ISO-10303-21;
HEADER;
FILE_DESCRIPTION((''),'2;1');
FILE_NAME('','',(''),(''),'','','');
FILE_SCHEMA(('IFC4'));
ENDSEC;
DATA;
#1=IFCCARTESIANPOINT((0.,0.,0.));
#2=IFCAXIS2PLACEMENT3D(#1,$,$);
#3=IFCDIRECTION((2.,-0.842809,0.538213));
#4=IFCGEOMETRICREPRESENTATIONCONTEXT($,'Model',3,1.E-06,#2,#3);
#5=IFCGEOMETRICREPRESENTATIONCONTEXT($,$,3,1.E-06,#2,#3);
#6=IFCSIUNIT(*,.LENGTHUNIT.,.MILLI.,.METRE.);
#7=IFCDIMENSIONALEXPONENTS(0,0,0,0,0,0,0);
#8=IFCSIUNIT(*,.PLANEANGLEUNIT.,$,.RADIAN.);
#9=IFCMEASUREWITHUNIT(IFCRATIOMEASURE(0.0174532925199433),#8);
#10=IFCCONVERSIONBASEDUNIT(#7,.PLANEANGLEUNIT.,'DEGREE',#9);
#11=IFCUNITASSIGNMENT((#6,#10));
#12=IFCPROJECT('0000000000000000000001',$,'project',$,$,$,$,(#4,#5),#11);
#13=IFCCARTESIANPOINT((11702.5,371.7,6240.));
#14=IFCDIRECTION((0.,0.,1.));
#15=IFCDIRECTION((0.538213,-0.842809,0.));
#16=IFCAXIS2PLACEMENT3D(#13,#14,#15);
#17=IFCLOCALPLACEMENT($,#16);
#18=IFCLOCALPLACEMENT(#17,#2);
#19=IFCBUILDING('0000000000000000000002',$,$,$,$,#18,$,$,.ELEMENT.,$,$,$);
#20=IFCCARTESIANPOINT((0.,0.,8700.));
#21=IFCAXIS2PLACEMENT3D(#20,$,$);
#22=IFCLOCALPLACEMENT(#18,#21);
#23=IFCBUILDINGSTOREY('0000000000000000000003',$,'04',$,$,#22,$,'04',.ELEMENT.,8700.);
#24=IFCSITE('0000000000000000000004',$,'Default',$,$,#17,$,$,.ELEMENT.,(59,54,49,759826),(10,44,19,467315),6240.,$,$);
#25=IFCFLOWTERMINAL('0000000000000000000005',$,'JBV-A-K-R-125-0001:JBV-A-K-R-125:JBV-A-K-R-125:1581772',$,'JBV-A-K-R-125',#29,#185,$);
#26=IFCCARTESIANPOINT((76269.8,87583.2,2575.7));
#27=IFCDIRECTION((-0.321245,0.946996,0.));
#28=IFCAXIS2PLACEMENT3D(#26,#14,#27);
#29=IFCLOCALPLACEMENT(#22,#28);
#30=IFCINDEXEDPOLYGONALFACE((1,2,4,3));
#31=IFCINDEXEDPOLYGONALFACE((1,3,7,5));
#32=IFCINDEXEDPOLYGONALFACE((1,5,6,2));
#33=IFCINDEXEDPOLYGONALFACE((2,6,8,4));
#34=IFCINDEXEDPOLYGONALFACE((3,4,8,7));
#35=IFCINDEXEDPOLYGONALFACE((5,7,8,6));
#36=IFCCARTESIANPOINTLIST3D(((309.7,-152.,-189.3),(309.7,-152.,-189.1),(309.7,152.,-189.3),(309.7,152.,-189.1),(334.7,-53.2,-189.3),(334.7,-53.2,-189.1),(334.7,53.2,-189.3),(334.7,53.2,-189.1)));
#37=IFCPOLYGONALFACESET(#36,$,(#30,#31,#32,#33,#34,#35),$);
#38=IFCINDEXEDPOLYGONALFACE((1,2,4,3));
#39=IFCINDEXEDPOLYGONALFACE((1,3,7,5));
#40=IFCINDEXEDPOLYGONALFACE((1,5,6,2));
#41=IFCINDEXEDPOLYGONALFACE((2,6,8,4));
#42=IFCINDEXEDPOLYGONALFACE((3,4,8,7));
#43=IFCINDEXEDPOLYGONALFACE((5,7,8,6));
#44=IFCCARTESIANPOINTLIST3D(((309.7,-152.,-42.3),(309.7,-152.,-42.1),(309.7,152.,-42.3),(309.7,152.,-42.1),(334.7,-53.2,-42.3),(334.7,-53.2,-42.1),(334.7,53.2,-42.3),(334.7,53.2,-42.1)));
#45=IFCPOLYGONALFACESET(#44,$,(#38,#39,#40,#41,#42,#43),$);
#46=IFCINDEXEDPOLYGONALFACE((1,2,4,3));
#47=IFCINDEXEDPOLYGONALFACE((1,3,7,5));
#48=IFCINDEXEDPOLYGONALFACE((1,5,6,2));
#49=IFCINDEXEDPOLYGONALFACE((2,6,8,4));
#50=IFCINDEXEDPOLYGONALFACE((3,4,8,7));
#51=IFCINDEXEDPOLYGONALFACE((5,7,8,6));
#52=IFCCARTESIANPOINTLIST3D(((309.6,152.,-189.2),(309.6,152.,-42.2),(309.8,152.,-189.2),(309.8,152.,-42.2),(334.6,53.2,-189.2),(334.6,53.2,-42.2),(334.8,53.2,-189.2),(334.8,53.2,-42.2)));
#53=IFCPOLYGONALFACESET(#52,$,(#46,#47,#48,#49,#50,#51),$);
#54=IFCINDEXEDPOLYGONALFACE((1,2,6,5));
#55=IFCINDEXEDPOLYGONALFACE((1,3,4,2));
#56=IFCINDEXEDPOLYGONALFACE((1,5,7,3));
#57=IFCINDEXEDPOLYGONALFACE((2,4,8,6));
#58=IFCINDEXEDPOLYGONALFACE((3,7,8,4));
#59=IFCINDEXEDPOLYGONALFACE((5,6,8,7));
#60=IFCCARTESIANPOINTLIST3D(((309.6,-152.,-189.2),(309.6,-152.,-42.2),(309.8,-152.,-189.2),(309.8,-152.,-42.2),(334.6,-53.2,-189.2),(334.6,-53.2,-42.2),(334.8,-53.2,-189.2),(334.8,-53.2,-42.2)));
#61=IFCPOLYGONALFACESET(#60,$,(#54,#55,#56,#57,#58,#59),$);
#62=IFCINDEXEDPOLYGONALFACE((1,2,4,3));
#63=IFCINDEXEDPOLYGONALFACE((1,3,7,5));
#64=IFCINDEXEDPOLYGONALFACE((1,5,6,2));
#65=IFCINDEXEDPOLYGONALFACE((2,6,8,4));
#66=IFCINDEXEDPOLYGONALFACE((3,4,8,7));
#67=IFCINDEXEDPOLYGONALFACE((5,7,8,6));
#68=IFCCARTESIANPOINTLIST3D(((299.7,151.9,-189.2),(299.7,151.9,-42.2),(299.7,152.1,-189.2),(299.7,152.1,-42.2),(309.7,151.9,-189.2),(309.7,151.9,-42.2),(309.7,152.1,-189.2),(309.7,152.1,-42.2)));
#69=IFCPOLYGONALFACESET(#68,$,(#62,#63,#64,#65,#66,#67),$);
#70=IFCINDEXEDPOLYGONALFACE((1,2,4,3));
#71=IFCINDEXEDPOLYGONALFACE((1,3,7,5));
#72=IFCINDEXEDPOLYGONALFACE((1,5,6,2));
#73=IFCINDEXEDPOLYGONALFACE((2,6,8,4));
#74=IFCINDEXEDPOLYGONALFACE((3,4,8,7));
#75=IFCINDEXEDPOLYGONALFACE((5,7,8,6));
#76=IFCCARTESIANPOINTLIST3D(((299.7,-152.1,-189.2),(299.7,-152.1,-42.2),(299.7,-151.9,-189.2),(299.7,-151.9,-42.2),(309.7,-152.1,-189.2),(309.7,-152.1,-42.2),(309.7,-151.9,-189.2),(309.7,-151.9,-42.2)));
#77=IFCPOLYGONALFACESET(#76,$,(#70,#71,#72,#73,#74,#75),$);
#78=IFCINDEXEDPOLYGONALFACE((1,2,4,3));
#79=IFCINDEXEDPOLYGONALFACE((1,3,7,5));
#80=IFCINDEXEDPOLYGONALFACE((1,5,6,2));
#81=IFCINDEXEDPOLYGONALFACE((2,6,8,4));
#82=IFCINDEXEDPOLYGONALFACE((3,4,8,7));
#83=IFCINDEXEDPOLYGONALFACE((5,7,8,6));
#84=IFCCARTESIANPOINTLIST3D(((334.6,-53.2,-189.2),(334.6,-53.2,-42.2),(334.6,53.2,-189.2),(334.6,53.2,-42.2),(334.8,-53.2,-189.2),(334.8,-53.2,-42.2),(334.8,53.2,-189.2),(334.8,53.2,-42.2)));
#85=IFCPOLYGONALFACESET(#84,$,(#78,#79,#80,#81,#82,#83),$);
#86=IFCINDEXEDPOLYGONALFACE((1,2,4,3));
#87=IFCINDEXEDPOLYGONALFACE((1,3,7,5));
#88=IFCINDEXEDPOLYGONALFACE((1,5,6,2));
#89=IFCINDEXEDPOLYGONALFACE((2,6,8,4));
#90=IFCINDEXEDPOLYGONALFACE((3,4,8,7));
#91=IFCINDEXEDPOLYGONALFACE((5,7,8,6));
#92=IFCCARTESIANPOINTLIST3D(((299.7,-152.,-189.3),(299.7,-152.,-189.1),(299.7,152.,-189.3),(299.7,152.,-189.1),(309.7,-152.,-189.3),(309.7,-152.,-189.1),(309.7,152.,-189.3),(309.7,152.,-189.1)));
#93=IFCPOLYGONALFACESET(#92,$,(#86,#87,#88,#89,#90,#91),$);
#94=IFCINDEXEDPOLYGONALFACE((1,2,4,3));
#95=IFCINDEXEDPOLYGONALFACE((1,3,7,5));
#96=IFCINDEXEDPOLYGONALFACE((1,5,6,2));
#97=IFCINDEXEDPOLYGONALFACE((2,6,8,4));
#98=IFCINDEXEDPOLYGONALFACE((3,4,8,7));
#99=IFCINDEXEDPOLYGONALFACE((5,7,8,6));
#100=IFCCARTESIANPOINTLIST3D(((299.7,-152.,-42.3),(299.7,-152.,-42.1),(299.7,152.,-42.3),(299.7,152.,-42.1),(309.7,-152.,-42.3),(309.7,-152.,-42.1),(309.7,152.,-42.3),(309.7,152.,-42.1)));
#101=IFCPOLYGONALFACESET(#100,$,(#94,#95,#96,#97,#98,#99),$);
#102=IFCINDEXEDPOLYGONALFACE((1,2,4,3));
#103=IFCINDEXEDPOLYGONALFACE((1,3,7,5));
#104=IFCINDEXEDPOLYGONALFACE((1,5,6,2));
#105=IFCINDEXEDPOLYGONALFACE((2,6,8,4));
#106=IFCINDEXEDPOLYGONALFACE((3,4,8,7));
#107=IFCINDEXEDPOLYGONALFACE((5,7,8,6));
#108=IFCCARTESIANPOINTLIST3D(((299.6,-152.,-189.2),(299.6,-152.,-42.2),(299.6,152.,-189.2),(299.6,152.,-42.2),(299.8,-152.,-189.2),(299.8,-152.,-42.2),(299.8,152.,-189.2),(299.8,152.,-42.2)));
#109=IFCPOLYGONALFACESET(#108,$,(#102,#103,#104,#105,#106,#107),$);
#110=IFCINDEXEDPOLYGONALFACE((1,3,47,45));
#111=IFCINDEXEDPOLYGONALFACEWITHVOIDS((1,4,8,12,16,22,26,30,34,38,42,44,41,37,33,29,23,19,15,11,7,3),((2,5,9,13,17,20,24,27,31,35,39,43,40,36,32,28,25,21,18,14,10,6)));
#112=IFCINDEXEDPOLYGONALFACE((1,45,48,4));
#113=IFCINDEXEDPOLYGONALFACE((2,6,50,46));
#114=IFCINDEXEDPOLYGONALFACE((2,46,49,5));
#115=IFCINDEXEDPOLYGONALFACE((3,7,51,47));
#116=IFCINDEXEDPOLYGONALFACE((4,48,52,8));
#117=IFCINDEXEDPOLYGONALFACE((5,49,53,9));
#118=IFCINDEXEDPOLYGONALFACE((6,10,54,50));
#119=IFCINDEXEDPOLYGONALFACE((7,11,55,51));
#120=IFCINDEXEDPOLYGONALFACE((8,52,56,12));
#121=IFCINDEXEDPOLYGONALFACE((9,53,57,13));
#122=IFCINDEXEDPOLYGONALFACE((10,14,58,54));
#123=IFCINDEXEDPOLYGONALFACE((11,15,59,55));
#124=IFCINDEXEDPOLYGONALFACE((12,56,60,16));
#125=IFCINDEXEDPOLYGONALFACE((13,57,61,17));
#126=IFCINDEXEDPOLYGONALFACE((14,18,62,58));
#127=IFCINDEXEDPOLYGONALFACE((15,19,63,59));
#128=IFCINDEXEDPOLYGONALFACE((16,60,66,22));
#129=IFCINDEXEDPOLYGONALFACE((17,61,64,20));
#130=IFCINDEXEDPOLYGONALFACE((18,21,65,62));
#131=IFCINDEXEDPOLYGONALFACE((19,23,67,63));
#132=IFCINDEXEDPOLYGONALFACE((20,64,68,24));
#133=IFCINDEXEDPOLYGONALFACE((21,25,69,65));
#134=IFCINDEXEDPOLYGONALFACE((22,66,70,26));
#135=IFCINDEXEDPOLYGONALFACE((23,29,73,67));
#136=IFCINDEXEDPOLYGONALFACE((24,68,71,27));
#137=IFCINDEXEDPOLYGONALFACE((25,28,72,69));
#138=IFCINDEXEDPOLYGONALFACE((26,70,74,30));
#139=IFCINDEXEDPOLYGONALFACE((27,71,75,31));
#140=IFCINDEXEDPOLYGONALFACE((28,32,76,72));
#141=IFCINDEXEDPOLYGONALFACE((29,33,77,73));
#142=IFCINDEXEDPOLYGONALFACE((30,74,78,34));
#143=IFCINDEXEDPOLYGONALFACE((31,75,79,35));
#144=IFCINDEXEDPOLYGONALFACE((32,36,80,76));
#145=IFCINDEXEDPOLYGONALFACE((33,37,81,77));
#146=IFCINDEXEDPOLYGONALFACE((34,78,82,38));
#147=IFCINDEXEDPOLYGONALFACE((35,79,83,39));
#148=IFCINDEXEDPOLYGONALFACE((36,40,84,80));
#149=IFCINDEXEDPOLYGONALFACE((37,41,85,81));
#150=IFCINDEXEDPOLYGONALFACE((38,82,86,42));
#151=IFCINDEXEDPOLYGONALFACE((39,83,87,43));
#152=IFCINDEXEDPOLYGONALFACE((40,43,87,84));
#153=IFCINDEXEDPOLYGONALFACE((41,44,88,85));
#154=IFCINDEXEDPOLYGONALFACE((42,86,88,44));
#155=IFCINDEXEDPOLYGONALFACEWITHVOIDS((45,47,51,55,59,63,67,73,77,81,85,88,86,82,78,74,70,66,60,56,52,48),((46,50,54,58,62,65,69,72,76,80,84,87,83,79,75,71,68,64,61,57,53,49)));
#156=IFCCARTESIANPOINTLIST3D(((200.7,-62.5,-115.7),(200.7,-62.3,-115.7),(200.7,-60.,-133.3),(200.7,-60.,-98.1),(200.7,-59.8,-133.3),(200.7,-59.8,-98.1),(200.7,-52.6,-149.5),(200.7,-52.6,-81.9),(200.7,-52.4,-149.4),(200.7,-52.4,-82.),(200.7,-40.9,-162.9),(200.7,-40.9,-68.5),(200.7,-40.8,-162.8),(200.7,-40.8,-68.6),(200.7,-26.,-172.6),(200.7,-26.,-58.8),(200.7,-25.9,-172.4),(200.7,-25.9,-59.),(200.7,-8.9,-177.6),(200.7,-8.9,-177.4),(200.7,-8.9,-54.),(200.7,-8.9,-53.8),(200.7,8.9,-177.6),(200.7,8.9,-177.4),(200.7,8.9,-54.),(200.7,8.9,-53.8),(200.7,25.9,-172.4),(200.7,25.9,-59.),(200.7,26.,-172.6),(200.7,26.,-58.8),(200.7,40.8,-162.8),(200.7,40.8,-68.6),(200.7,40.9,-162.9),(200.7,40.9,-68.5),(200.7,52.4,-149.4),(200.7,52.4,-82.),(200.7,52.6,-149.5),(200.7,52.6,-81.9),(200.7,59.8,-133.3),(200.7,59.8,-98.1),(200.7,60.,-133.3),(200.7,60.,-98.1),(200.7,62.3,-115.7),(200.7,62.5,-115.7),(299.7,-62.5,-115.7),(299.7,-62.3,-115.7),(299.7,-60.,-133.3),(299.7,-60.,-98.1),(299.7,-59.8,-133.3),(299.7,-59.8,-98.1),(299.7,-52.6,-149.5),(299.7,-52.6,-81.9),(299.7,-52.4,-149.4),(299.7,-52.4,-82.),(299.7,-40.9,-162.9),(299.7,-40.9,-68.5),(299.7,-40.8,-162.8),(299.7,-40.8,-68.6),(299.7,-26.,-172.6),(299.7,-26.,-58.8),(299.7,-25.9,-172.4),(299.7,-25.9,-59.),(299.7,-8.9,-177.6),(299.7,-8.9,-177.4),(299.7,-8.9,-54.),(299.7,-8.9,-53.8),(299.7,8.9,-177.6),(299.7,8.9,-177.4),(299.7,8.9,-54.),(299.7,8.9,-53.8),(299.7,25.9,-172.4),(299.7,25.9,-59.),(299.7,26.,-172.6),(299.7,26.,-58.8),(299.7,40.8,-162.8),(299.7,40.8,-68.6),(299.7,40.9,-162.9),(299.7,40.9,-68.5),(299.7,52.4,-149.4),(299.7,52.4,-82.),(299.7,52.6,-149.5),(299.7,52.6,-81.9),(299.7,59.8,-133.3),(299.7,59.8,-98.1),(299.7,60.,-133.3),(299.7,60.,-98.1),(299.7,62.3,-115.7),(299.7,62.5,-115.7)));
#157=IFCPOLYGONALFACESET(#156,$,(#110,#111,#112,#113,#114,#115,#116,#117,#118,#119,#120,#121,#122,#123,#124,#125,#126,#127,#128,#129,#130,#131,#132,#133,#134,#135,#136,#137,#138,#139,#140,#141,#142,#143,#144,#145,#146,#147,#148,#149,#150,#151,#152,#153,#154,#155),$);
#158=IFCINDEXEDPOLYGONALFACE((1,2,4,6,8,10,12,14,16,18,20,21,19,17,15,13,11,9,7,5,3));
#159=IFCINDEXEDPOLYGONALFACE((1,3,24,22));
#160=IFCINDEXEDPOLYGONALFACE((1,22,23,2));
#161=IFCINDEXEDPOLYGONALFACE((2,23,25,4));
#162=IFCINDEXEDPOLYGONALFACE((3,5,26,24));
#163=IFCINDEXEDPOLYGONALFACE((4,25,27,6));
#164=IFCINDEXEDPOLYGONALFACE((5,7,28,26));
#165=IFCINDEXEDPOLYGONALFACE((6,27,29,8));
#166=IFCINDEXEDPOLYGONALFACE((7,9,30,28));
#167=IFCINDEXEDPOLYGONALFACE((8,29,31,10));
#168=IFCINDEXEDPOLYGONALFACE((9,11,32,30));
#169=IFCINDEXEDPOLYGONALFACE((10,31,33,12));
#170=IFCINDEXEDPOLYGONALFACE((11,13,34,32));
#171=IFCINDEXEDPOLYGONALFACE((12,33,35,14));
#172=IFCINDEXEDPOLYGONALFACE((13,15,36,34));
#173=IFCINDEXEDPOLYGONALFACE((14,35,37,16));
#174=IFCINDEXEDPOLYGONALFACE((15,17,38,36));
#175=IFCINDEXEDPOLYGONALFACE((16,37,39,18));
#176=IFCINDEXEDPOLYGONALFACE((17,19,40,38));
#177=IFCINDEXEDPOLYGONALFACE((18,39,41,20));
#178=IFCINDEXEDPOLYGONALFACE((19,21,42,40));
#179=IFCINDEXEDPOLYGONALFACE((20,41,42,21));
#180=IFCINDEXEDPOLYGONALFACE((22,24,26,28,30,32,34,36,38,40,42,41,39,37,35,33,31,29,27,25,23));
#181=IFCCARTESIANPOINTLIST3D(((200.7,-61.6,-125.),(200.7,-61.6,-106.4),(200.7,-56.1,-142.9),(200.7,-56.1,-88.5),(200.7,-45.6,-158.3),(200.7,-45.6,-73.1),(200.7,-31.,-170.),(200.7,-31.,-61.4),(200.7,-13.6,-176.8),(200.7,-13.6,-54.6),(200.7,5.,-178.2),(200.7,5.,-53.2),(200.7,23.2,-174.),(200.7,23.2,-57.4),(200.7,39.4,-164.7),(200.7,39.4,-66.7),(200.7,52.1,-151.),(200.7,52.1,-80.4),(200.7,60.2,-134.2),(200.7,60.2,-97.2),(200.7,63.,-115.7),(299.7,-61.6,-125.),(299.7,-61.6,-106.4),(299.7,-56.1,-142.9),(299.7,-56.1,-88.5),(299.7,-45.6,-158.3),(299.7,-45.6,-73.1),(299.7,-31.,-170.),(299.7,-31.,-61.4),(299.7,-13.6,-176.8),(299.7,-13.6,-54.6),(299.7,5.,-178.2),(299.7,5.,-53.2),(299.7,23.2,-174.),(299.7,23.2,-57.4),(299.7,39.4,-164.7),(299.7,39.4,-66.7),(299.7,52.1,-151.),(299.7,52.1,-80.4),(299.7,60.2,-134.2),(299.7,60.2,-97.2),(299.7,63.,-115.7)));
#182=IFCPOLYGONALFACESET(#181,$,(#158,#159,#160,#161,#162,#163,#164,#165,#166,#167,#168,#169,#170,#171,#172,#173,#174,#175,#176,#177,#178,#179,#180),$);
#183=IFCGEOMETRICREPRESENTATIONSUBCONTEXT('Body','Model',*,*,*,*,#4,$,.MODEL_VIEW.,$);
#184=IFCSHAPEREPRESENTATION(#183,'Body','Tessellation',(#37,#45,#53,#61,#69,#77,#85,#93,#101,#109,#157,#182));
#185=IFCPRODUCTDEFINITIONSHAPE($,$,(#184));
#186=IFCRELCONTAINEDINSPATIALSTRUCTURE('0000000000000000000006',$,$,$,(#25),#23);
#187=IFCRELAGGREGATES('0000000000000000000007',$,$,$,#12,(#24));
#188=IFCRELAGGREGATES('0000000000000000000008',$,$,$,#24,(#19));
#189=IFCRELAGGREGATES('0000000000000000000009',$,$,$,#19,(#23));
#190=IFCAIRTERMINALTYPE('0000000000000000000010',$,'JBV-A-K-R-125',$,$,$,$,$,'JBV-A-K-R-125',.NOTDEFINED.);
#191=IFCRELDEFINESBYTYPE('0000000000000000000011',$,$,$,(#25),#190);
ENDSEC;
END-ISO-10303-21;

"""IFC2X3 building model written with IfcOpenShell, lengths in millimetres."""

from ifc_helpers import new_model, entity, si_unit, converted_unit, direction, frame, frame_2d, origin, origin_2d_with_axis, place, context, subcontext, project, spatial, polyline, circle_curve, parameter, trimmed, segment, composite_curve, rectangle, circle, outline, extrude, source, transform, mapped, type_object, type_shapes, element, save


model = new_model("IFC2X3")

# Units and contexts
model_context = context("Model", 3, precision=1e-06, world=origin(), true_north=direction((2.0, -0.842809, 0.538213)))
context_of_model = context(None, 3, precision=1e-06, world=origin(), true_north=direction((2.0, -0.842809, 0.538213)))
body_context = subcontext(model_context, "Body", "Model", "MODEL_VIEW")
ifc_project = project(units=[si_unit("LENGTHUNIT", "METRE", prefix="MILLI"), converted_unit("PLANEANGLEUNIT", "DEGREE", entity("IfcRatioMeasure", 0.0174532925199433), si_unit("PLANEANGLEUNIT", "RADIAN"), dimensions=[0, 0, 0, 0, 0, 0, 0])], contexts=[model_context, context_of_model])

# Site, building, storey
site_placement = place(None, frame((11702.5, 371.7, 6240.0), z_axis=(0.0, 0.0, 1.0), x_axis=(0.538213, -0.842809, 0.0)))
site = spatial("IfcSite", under=ifc_project, at=site_placement, Name="Default", CompositionType="ELEMENT", RefLatitude=(59, 54, 49, 759826), RefLongitude=(10, 44, 19, 467315), RefElevation=6240.0)
building_placement = place(site_placement, origin())
building = spatial("IfcBuilding", under=site, at=building_placement, CompositionType="ELEMENT")
storey_placement = place(building_placement, frame((0.0, 0.0, 8700.0)))
storey = spatial("IfcBuildingStorey", under=building, at=storey_placement, Name="04", LongName="04", CompositionType="ELEMENT", Elevation=8700.0)

# Flow terminal
air_terminal_type_1 = type_object("IfcAirTerminalType", Name="JBV-A-K-R-125", ElementType="JBV-A-K-R-125", PredefinedType="NOTDEFINED")
shared_shape_1 = source(origin(), body_context, "Body", "SweptSolid", [
    extrude(outline(polyline([(-152.0, -12.5), (152.0, -12.5), (53.2, 12.5), (-53.2, 12.5), (-152.0, -12.5)])), frame((322.2, 0.0, -189.3), z_axis=(0.0, 0.0, 1.0), x_axis=(0.0, -1.0, 0.0)), (0.0, 0.0, 1.0), 0.2),
    extrude(outline(polyline([(-152.0, -12.5), (152.0, -12.5), (53.2, 12.5), (-53.2, 12.5), (-152.0, -12.5)])), frame((322.2, 0.0, -42.3), z_axis=(0.0, 0.0, 1.0), x_axis=(0.0, -1.0, 0.0)), (0.0, 0.0, 1.0), 0.2),
    extrude(rectangle(XDim=0.2, YDim=101.9, at=frame_2d((0.0, 0.0), x_axis=(1.0, 0.0))), frame((322.2, 102.6, -189.2), z_axis=(0.0, 0.0, 1.0), x_axis=(0.969446, 0.245305, 0.0)), (0.0, 0.0, 1.0), 147.0),
    extrude(rectangle(XDim=0.2, YDim=101.9, at=frame_2d((0.0, 0.0), x_axis=(1.0, 0.0))), frame((322.2, -102.6, -189.2), z_axis=(0.0, 0.0, 1.0), x_axis=(-0.969446, 0.245305, 0.0)), (0.0, 0.0, 1.0), 147.0),
    extrude(rectangle(XDim=0.2, YDim=10.0, at=frame_2d((0.0, 0.0), x_axis=(1.0, 0.0))), frame((304.7, 152.0, -189.2), z_axis=(0.0, 0.0, 1.0), x_axis=(0.0, 1.0, 0.0)), (0.0, 0.0, 1.0), 147.0),
    extrude(rectangle(XDim=0.2, YDim=10.0, at=frame_2d((0.0, 0.0), x_axis=(1.0, 0.0))), frame((304.7, -152.0, -189.2), z_axis=(0.0, 0.0, 1.0), x_axis=(0.0, 1.0, 0.0)), (0.0, 0.0, 1.0), 147.0),
    extrude(rectangle(XDim=0.2, YDim=106.4, at=frame_2d((0.0, 0.0), x_axis=(1.0, 0.0))), frame((334.7, 0.0, -189.2)), (0.0, 0.0, 1.0), 147.0),
    extrude(rectangle(XDim=304.0, YDim=10.0, at=frame_2d((0.0, 0.0), x_axis=(1.0, 0.0))), frame((304.7, 0.0, -189.3), z_axis=(0.0, 0.0, 1.0), x_axis=(0.0, -1.0, 0.0)), (0.0, 0.0, 1.0), 0.2),
    extrude(rectangle(XDim=304.0, YDim=10.0, at=frame_2d((0.0, 0.0), x_axis=(1.0, 0.0))), frame((304.7, 0.0, -42.3), z_axis=(0.0, 0.0, 1.0), x_axis=(0.0, -1.0, 0.0)), (0.0, 0.0, 1.0), 0.2),
    extrude(rectangle(XDim=0.2, YDim=304.0, at=frame_2d((0.0, 0.0), x_axis=(1.0, 0.0))), frame((299.7, 0.0, -189.2)), (0.0, 0.0, 1.0), 147.0),
    extrude(outline(composite_curve([segment(trimmed(circle_curve(origin_2d_with_axis(), 62.5), [parameter(0.0)], [parameter(180.0)], True, "PARAMETER"), True, "CONTINUOUS"), segment(trimmed(circle_curve(origin_2d_with_axis(), 62.5), [parameter(180.0)], [parameter(360.0)], True, "PARAMETER"), True, "CONTINUOUS")], self_intersect=False), holes=[composite_curve([segment(trimmed(circle_curve(origin_2d_with_axis(), 62.3), [parameter(180.0)], [parameter(360.0)], True, "PARAMETER"), False, "CONTINUOUS"), segment(trimmed(circle_curve(origin_2d_with_axis(), 62.3), [parameter(0.0)], [parameter(180.0)], True, "PARAMETER"), False, "CONTINUOUS")], self_intersect=False)]), frame((200.7, 0.0, -115.7), z_axis=(1.0, 0.0, 0.0), x_axis=(0.0, 1.0, 0.0)), (0.0, 0.0, 1.0), 99.0),
    extrude(circle(Radius=62.6, at=frame_2d((0.0, 0.0), x_axis=(1.0, 0.0))), frame((200.7, 0.3, -115.7), z_axis=(1.0, 0.0, 0.0), x_axis=(0.0, 1.0, 0.0)), (0.0, 0.0, 1.0), 99.0),
])
type_shapes(air_terminal_type_1, [shared_shape_1])
flow_terminal_1_placement = place(storey_placement, frame((76269.8, 87583.2, 2575.7), z_axis=(0.0, 0.0, 1.0), x_axis=(-0.321245, 0.946996, 0.0)))
element("IfcFlowTerminal", 1, at=flow_terminal_1_placement, inside=storey, type_object=air_terminal_type_1, Name="JBV-A-K-R-125-0001:JBV-A-K-R-125:JBV-A-K-R-125:1581772", ObjectType="JBV-A-K-R-125", context=body_context, shape_type="MappedRepresentation", body=[
    mapped(shared_shape_1, transform((0.0, 0.0, 0.0), scale=1.0)),
])

save(model, "model.ifc")
